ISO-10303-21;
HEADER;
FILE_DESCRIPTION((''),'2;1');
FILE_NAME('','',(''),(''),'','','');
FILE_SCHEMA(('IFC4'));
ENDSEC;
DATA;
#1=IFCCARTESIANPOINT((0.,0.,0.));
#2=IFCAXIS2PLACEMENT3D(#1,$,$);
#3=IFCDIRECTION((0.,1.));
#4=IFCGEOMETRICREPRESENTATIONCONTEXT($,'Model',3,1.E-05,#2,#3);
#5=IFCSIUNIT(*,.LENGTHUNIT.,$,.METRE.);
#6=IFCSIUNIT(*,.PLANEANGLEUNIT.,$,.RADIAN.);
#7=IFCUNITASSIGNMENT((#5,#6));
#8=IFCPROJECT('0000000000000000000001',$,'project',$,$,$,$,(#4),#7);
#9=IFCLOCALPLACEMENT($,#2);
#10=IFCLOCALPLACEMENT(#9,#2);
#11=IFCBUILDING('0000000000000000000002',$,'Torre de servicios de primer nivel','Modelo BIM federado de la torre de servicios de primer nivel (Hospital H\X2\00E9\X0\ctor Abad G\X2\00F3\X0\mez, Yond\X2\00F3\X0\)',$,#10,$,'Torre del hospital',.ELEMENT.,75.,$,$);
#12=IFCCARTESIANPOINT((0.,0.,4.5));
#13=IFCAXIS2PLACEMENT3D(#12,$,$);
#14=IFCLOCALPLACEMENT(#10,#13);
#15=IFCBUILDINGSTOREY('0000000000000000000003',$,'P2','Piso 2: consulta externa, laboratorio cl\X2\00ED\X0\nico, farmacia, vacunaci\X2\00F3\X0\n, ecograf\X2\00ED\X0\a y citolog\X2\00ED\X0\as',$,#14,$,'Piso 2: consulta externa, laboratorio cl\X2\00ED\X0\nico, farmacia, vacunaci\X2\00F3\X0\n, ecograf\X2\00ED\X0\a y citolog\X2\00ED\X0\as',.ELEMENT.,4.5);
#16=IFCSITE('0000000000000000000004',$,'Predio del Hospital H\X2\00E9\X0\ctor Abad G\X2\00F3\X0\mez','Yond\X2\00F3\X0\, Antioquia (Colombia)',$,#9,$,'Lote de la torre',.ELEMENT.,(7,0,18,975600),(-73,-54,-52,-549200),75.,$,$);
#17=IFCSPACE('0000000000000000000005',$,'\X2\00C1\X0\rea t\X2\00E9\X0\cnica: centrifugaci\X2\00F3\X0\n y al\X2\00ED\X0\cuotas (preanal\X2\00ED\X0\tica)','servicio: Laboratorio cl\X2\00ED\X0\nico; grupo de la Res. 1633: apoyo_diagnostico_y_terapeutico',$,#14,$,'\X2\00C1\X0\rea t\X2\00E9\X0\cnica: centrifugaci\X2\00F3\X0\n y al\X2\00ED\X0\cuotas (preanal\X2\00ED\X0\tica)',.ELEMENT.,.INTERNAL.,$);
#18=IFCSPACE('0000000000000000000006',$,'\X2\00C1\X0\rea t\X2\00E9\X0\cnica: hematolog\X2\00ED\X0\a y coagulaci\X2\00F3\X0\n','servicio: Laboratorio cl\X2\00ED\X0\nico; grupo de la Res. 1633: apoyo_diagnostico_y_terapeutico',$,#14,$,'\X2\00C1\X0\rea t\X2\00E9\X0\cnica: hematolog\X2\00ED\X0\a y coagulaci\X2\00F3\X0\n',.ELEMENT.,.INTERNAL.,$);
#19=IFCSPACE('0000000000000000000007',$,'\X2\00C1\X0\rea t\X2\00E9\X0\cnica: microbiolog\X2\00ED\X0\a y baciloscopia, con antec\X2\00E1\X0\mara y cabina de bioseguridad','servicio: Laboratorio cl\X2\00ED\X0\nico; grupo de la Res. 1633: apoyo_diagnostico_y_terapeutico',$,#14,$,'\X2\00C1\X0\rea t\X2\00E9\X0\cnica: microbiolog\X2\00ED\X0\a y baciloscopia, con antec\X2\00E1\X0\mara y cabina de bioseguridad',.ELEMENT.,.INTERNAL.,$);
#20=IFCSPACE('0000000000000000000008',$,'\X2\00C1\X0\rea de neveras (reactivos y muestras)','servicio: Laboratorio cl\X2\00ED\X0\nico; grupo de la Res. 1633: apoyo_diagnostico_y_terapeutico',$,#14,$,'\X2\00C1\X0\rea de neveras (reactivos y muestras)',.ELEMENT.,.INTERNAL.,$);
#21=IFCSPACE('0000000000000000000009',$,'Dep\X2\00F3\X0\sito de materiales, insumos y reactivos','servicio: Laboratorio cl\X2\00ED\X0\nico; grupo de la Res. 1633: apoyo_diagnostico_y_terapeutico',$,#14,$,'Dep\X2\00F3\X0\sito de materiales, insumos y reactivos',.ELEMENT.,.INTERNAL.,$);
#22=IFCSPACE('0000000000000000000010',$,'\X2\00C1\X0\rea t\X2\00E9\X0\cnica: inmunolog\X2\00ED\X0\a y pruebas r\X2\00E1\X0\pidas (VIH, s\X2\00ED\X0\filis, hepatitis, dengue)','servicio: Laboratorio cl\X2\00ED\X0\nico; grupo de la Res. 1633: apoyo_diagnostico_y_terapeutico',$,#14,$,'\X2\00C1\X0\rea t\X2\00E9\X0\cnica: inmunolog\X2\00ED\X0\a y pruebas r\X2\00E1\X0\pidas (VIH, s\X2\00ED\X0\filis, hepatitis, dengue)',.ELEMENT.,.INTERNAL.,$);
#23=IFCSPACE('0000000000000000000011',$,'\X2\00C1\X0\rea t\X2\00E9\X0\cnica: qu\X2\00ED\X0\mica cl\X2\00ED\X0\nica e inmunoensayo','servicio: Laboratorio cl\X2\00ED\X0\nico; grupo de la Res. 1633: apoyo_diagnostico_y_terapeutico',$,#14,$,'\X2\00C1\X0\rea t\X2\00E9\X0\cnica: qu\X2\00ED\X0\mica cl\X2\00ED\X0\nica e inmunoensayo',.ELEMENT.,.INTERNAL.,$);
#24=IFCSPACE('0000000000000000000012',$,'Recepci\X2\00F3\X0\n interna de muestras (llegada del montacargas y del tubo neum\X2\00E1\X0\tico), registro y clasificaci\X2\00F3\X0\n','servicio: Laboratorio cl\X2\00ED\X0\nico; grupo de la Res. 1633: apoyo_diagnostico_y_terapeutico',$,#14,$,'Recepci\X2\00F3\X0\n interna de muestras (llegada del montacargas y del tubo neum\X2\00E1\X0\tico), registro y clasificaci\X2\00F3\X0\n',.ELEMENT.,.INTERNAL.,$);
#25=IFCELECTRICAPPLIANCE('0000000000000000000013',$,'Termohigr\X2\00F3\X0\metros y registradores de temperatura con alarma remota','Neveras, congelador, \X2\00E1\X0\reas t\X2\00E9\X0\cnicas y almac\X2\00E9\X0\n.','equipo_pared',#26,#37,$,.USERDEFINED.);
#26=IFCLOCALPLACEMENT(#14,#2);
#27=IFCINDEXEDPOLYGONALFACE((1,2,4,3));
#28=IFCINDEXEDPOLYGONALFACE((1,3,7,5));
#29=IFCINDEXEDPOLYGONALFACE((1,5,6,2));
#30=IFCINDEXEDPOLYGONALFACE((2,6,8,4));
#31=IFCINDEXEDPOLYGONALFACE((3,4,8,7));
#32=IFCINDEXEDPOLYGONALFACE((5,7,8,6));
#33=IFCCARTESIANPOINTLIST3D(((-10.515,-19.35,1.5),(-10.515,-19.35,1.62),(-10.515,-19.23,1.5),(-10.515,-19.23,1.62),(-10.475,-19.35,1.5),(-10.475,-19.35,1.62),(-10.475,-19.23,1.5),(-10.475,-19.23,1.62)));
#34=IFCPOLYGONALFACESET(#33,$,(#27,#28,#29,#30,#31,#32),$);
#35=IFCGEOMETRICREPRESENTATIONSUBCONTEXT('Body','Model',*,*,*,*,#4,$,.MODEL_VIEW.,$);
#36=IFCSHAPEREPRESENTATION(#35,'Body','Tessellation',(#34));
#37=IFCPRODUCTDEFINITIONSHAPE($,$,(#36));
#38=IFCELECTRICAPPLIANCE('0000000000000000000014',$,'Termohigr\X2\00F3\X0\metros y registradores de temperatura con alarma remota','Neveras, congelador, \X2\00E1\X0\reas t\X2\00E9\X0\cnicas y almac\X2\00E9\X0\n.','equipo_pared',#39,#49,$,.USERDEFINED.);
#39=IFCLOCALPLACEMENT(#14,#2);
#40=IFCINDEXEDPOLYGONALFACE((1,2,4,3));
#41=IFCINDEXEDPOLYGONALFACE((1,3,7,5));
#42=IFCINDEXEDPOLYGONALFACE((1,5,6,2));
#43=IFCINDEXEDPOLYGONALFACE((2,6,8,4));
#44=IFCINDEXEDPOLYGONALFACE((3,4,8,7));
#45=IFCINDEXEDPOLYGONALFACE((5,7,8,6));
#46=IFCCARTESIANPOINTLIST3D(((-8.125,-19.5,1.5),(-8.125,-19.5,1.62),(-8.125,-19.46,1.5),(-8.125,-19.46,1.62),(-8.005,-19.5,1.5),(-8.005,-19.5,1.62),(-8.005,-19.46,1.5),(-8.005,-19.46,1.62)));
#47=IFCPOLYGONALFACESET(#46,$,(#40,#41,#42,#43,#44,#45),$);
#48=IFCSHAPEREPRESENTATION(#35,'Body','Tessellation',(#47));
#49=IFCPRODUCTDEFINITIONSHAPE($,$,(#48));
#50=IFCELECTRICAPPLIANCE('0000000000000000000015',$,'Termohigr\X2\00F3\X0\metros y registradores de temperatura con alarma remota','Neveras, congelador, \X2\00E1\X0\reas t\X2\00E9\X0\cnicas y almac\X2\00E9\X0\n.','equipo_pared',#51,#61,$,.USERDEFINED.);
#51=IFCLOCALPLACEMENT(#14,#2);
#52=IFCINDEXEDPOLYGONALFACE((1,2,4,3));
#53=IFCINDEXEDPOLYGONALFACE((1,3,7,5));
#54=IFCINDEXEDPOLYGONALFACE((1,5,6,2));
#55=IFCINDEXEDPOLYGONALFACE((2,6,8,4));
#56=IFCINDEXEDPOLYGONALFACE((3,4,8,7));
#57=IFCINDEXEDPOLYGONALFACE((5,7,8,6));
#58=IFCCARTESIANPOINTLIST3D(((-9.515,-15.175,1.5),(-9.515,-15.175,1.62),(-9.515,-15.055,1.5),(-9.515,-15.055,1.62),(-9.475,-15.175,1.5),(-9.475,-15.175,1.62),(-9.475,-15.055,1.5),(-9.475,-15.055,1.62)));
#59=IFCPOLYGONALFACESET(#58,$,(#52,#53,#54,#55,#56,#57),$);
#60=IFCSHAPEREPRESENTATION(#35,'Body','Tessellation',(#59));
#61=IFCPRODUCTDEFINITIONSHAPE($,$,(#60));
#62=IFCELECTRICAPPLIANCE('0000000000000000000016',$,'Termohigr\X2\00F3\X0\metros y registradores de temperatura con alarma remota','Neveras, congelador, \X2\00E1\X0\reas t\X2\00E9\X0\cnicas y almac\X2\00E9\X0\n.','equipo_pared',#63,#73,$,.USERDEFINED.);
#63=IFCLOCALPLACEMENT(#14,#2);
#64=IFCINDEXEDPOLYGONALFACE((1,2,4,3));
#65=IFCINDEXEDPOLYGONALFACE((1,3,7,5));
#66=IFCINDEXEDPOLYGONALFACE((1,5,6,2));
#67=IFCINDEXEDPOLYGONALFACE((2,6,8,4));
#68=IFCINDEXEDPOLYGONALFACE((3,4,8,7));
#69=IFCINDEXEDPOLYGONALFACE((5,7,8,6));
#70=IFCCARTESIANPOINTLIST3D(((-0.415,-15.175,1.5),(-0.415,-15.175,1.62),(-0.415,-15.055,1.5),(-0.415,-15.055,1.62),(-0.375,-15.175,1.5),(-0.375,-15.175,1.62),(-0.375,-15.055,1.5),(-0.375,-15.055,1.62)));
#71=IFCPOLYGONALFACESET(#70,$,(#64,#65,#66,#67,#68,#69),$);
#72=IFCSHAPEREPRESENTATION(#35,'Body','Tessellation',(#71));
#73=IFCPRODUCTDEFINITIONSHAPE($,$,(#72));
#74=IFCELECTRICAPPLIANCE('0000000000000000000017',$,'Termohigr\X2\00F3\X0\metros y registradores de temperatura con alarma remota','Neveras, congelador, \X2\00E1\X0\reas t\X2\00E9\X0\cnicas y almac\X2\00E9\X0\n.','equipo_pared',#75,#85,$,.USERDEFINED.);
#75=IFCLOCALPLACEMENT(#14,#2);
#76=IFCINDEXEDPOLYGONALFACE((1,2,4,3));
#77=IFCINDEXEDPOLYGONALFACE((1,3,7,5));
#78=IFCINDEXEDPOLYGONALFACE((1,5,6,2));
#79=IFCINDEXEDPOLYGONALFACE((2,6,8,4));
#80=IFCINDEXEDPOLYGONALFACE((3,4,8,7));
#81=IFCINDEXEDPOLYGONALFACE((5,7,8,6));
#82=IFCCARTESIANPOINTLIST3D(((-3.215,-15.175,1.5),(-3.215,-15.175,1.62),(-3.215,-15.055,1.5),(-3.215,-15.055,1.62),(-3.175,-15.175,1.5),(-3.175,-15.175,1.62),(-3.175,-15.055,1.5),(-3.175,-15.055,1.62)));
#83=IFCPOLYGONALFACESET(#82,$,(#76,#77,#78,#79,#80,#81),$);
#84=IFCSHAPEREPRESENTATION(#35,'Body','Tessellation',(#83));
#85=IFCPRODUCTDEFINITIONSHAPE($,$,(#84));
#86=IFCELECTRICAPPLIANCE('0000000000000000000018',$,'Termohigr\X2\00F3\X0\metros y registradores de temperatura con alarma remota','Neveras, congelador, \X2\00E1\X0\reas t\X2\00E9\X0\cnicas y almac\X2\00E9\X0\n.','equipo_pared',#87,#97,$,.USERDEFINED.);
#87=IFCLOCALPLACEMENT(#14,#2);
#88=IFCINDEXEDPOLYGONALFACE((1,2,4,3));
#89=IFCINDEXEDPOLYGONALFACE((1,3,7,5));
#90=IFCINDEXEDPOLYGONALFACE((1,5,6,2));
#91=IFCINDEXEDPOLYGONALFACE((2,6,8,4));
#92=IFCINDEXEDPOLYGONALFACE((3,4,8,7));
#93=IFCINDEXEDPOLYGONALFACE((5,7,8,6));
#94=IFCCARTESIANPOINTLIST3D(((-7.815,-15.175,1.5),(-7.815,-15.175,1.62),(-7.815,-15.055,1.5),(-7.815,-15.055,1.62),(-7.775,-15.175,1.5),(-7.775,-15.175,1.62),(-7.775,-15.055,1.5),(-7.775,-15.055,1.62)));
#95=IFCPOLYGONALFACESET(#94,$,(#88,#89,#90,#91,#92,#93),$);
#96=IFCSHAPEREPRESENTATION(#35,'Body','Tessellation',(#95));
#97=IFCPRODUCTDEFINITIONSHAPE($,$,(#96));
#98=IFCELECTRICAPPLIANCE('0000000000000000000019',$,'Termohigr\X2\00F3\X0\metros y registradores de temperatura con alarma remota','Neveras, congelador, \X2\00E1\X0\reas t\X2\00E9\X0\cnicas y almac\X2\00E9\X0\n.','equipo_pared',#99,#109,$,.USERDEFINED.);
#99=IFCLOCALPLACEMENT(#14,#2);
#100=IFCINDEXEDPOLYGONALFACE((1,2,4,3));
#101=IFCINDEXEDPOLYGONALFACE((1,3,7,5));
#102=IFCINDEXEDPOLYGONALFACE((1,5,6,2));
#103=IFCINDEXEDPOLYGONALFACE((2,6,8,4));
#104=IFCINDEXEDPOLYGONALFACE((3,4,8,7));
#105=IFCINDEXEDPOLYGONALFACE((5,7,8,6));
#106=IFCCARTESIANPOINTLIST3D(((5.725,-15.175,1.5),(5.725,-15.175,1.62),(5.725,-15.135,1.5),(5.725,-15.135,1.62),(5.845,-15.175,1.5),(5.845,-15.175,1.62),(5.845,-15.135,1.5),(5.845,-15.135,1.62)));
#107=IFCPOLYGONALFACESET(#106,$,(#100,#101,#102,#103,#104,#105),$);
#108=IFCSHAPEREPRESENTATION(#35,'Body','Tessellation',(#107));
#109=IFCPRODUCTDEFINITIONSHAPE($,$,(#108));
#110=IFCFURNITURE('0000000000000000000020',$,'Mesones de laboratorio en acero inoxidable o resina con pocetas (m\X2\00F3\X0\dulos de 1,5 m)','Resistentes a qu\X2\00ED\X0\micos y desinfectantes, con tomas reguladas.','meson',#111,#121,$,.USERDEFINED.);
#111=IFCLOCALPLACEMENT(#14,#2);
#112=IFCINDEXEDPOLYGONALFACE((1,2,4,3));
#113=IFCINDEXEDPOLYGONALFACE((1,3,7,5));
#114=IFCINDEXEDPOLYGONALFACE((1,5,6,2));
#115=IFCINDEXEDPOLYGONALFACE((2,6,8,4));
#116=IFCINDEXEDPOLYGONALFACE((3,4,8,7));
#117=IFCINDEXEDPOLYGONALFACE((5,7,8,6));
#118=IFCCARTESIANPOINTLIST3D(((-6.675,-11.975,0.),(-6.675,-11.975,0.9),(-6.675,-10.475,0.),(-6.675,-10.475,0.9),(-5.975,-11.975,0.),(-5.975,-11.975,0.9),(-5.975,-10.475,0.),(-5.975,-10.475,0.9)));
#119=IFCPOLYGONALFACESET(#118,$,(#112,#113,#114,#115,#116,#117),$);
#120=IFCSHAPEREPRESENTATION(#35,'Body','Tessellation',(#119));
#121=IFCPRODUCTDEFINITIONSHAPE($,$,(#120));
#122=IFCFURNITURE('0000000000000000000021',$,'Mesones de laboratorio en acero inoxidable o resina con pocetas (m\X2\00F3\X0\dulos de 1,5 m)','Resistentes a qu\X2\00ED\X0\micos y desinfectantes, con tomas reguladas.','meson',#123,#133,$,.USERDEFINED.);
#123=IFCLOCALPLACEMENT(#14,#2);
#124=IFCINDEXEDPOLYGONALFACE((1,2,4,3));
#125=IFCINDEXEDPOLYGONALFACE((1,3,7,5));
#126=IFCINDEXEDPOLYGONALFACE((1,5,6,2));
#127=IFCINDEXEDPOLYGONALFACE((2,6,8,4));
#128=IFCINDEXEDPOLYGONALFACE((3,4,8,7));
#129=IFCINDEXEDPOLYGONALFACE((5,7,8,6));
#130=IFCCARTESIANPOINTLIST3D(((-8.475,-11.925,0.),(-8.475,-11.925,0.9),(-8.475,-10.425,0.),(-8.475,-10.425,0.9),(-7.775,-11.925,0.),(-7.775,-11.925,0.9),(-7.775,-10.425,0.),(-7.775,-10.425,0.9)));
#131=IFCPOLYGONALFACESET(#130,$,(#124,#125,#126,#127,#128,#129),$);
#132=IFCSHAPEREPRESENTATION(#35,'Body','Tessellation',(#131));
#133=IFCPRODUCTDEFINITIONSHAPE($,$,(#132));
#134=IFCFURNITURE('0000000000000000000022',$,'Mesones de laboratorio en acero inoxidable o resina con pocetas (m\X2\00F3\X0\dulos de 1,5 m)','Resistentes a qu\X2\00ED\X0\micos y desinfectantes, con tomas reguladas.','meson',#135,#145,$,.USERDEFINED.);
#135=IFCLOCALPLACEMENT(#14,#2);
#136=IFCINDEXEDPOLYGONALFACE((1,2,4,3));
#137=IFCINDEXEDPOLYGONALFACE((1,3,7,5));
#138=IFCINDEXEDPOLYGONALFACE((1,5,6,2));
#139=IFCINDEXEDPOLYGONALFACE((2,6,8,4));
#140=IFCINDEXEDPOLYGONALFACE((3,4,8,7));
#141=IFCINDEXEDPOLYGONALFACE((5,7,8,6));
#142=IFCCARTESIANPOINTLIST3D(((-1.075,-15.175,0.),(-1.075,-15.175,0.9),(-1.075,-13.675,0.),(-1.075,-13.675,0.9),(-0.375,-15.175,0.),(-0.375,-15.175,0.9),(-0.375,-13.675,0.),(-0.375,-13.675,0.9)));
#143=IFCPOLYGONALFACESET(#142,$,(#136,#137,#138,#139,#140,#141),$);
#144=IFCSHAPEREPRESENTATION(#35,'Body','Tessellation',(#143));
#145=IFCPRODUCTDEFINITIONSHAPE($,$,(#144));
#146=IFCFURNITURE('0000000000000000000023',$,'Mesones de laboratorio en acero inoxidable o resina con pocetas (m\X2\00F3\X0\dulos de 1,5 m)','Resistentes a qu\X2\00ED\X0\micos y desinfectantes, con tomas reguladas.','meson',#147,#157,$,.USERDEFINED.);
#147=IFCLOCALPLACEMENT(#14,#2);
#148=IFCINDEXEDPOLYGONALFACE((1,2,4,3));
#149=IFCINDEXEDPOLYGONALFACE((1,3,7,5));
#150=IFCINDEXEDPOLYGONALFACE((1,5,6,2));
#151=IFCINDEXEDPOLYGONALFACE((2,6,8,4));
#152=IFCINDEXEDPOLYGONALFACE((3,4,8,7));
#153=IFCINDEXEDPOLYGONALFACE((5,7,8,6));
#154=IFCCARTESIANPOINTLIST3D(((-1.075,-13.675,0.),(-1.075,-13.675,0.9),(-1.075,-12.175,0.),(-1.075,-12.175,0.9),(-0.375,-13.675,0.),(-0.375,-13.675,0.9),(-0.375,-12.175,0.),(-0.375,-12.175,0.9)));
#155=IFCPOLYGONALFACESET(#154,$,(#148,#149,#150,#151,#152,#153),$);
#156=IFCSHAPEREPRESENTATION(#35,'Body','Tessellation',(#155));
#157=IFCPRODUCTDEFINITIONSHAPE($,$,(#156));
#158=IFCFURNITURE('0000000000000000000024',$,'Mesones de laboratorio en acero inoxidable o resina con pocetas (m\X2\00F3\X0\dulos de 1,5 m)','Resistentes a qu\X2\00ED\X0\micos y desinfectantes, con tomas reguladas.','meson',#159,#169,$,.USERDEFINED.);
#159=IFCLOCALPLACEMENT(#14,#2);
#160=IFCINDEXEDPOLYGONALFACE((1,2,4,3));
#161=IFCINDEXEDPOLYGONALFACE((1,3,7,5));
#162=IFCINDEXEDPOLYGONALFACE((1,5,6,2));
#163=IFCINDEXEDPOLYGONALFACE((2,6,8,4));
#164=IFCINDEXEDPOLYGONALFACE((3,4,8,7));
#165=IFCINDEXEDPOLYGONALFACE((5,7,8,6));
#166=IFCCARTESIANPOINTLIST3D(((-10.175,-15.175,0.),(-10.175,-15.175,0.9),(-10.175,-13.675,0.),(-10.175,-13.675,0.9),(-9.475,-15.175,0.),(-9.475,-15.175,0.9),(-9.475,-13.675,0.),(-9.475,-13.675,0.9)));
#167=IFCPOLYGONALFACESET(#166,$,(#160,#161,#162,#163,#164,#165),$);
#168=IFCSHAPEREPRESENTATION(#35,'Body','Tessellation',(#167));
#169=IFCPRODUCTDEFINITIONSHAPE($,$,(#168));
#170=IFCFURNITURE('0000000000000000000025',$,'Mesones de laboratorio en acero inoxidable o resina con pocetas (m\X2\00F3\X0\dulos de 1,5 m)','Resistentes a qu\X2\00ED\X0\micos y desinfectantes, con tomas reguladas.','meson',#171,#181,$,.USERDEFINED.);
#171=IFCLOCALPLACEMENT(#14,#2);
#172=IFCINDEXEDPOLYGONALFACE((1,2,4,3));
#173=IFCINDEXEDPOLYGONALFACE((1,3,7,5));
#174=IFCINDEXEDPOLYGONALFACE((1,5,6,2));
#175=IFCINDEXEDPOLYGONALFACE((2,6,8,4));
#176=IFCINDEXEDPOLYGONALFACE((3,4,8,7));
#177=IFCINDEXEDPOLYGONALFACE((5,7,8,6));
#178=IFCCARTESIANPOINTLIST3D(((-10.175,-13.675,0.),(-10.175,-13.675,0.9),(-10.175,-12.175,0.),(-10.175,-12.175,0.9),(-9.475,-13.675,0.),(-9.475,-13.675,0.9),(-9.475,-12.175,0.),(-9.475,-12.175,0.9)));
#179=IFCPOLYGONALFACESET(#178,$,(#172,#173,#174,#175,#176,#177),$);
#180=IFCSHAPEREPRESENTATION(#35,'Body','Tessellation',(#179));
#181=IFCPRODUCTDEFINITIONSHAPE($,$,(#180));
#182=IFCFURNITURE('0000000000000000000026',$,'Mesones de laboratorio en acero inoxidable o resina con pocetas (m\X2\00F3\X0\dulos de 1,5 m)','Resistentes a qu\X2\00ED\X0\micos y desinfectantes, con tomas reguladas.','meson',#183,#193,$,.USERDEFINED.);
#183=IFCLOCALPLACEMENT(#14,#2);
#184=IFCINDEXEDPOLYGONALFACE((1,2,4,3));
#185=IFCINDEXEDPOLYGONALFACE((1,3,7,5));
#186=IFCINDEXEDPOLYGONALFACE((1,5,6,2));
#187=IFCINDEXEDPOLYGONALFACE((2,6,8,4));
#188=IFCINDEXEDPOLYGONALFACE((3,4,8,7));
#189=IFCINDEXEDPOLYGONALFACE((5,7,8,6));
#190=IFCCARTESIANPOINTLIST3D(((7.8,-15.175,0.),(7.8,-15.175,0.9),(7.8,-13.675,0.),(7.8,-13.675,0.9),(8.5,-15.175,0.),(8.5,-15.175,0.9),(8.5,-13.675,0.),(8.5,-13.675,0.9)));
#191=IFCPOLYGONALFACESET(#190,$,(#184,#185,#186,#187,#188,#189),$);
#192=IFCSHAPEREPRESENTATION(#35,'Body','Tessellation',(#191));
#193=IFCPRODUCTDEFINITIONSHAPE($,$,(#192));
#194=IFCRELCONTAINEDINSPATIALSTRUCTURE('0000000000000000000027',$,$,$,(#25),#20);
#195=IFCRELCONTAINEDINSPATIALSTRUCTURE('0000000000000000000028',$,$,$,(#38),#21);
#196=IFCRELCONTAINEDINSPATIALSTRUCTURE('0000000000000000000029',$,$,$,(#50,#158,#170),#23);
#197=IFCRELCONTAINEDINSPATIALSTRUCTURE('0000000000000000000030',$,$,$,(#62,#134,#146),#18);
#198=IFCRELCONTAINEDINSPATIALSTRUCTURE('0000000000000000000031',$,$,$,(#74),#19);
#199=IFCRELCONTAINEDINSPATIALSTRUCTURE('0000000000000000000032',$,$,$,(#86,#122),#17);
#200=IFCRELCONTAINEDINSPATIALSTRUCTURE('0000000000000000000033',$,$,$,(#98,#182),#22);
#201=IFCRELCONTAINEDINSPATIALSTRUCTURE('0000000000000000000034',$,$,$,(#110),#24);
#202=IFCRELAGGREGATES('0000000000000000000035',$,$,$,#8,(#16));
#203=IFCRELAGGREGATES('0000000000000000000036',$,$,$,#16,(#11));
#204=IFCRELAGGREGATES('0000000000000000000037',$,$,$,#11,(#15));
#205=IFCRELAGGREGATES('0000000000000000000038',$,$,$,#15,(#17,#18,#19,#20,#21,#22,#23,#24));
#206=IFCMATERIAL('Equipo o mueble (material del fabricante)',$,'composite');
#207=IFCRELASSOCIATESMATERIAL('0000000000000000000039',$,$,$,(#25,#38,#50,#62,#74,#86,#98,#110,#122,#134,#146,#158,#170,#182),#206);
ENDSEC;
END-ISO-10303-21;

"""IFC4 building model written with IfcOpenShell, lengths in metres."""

from ifc_helpers import new_model, si_unit, direction, frame, origin, place, context, subcontext, project, spatial, rectangle, extrude, material, element, save


model = new_model("IFC4")

# Units and contexts
model_context = context("Model", 3, precision=1e-05, world=origin(), true_north=direction((0.0, 1.0)))
body_context = subcontext(model_context, "Body", "Model", "MODEL_VIEW")
ifc_project = project(units=[si_unit("LENGTHUNIT", "METRE"), si_unit("PLANEANGLEUNIT", "RADIAN")], contexts=[model_context])

# Site, building, storey, space
site_placement = place(None, origin())
site = spatial("IfcSite", under=ifc_project, at=site_placement, Name="Predio del Hospital Héctor Abad Gómez", Description="Yondó, Antioquia (Colombia)", LongName="Lote de la torre", CompositionType="ELEMENT", RefLatitude=(7, 0, 18, 975600), RefLongitude=(-73, -54, -52, -549200), RefElevation=75.0)
building_placement = place(site_placement, origin())
building = spatial("IfcBuilding", under=site, at=building_placement, Name="Torre de servicios de primer nivel", Description="Modelo BIM federado de la torre de servicios de primer nivel (Hospital Héctor Abad Gómez, Yondó)", LongName="Torre del hospital", CompositionType="ELEMENT", ElevationOfRefHeight=75.0)
placement = place(building_placement, frame((0.0, 0.0, 4.5)))
storey = spatial("IfcBuildingStorey", under=building, at=placement, Name="P2", Description="Piso 2: consulta externa, laboratorio clínico, farmacia, vacunación, ecografía y citologías", LongName="Piso 2: consulta externa, laboratorio clínico, farmacia, vacunación, ecografía y citologías", CompositionType="ELEMENT", Elevation=4.5)
space_1 = spatial("IfcSpace", under=storey, at=placement, Name="Área técnica: centrifugación y alícuotas (preanalítica)", Description="servicio: Laboratorio clínico; grupo de la Res. 1633: apoyo_diagnostico_y_terapeutico", LongName="Área técnica: centrifugación y alícuotas (preanalítica)", CompositionType="ELEMENT", PredefinedType="INTERNAL")

# Shared definitions
ifc_material = material(Name="Equipo o mueble (material del fabricante)", Category="composite")

# Shared definitions
space_2 = spatial("IfcSpace", under=storey, at=placement, Name="Área técnica: hematología y coagulación", Description="servicio: Laboratorio clínico; grupo de la Res. 1633: apoyo_diagnostico_y_terapeutico", LongName="Área técnica: hematología y coagulación", CompositionType="ELEMENT", PredefinedType="INTERNAL")

# Shared definitions
space_3 = spatial("IfcSpace", under=storey, at=placement, Name="Área técnica: microbiología y baciloscopia, con antecámara y cabina de bioseguridad", Description="servicio: Laboratorio clínico; grupo de la Res. 1633: apoyo_diagnostico_y_terapeutico", LongName="Área técnica: microbiología y baciloscopia, con antecámara y cabina de bioseguridad", CompositionType="ELEMENT", PredefinedType="INTERNAL")

# Shared definitions
space_4 = spatial("IfcSpace", under=storey, at=placement, Name="Área de neveras (reactivos y muestras)", Description="servicio: Laboratorio clínico; grupo de la Res. 1633: apoyo_diagnostico_y_terapeutico", LongName="Área de neveras (reactivos y muestras)", CompositionType="ELEMENT", PredefinedType="INTERNAL")

# Shared definitions
space_5 = spatial("IfcSpace", under=storey, at=placement, Name="Depósito de materiales, insumos y reactivos", Description="servicio: Laboratorio clínico; grupo de la Res. 1633: apoyo_diagnostico_y_terapeutico", LongName="Depósito de materiales, insumos y reactivos", CompositionType="ELEMENT", PredefinedType="INTERNAL")

# Shared definitions
space_6 = spatial("IfcSpace", under=storey, at=placement, Name="Área técnica: inmunología y pruebas rápidas (VIH, sífilis, hepatitis, dengue)", Description="servicio: Laboratorio clínico; grupo de la Res. 1633: apoyo_diagnostico_y_terapeutico", LongName="Área técnica: inmunología y pruebas rápidas (VIH, sífilis, hepatitis, dengue)", CompositionType="ELEMENT", PredefinedType="INTERNAL")

# Shared definitions
space_7 = spatial("IfcSpace", under=storey, at=placement, Name="Área técnica: química clínica e inmunoensayo", Description="servicio: Laboratorio clínico; grupo de la Res. 1633: apoyo_diagnostico_y_terapeutico", LongName="Área técnica: química clínica e inmunoensayo", CompositionType="ELEMENT", PredefinedType="INTERNAL")

# Electric appliances
element("IfcElectricAppliance", 1, at=placement, inside=space_4, material=ifc_material, Name="Termohigrómetros y registradores de temperatura con alarma remota", Description="Neveras, congelador, áreas técnicas y almacén.", ObjectType="equipo_pared", PredefinedType="USERDEFINED", context=body_context, shape_type="SweptSolid", body=[
    extrude(rectangle(XDim=0.12, YDim=0.04), frame((-10.495, -19.29, 1.5), z_axis=(0.0, 0.0, 1.0), x_axis=(0.0, 1.0, 0.0)), (0.0, 0.0, 1.0), 0.12),
])
element("IfcElectricAppliance", 2, at=placement, inside=space_5, material=ifc_material, Name="Termohigrómetros y registradores de temperatura con alarma remota", Description="Neveras, congelador, áreas técnicas y almacén.", ObjectType="equipo_pared", PredefinedType="USERDEFINED", context=body_context, shape_type="SweptSolid", body=[
    extrude(rectangle(XDim=0.12, YDim=0.04), frame((-8.065, -19.48, 1.5)), (0.0, 0.0, 1.0), 0.12),
])
element("IfcElectricAppliance", 3, at=placement, inside=space_7, material=ifc_material, Name="Termohigrómetros y registradores de temperatura con alarma remota", Description="Neveras, congelador, áreas técnicas y almacén.", ObjectType="equipo_pared", PredefinedType="USERDEFINED", context=body_context, shape_type="SweptSolid", body=[
    extrude(rectangle(XDim=0.12, YDim=0.04), frame((-9.495, -15.115, 1.5), z_axis=(0.0, 0.0, 1.0), x_axis=(0.0, 1.0, 0.0)), (0.0, 0.0, 1.0), 0.12),
])
element("IfcElectricAppliance", 4, at=placement, inside=space_2, material=ifc_material, Name="Termohigrómetros y registradores de temperatura con alarma remota", Description="Neveras, congelador, áreas técnicas y almacén.", ObjectType="equipo_pared", PredefinedType="USERDEFINED", context=body_context, shape_type="SweptSolid", body=[
    extrude(rectangle(XDim=0.12, YDim=0.04), frame((-0.395, -15.115, 1.5), z_axis=(0.0, 0.0, 1.0), x_axis=(0.0, 1.0, 0.0)), (0.0, 0.0, 1.0), 0.12),
])
element("IfcElectricAppliance", 5, at=placement, inside=space_3, material=ifc_material, Name="Termohigrómetros y registradores de temperatura con alarma remota", Description="Neveras, congelador, áreas técnicas y almacén.", ObjectType="equipo_pared", PredefinedType="USERDEFINED", context=body_context, shape_type="SweptSolid", body=[
    extrude(rectangle(XDim=0.12, YDim=0.04), frame((-3.195, -15.115, 1.5), z_axis=(0.0, 0.0, 1.0), x_axis=(0.0, 1.0, 0.0)), (0.0, 0.0, 1.0), 0.12),
])
element("IfcElectricAppliance", 6, at=placement, inside=space_1, material=ifc_material, Name="Termohigrómetros y registradores de temperatura con alarma remota", Description="Neveras, congelador, áreas técnicas y almacén.", ObjectType="equipo_pared", PredefinedType="USERDEFINED", context=body_context, shape_type="SweptSolid", body=[
    extrude(rectangle(XDim=0.12, YDim=0.04), frame((-7.795, -15.115, 1.5), z_axis=(0.0, 0.0, 1.0), x_axis=(0.0, 1.0, 0.0)), (0.0, 0.0, 1.0), 0.12),
])
element("IfcElectricAppliance", 7, at=placement, inside=space_6, material=ifc_material, Name="Termohigrómetros y registradores de temperatura con alarma remota", Description="Neveras, congelador, áreas técnicas y almacén.", ObjectType="equipo_pared", PredefinedType="USERDEFINED", context=body_context, shape_type="SweptSolid", body=[
    extrude(rectangle(XDim=0.12, YDim=0.04), frame((5.785, -15.155, 1.5)), (0.0, 0.0, 1.0), 0.12),
])

# Shared definitions
space_8 = spatial("IfcSpace", under=storey, at=placement, Name="Recepción interna de muestras (llegada del montacargas y del tubo neumático), registro y clasificación", Description="servicio: Laboratorio clínico; grupo de la Res. 1633: apoyo_diagnostico_y_terapeutico", LongName="Recepción interna de muestras (llegada del montacargas y del tubo neumático), registro y clasificación", CompositionType="ELEMENT", PredefinedType="INTERNAL")

# Furniture
element("IfcFurniture", 8, at=placement, inside=space_8, material=ifc_material, Name="Mesones de laboratorio en acero inoxidable o resina con pocetas (módulos de 1,5 m)", Description="Resistentes a químicos y desinfectantes, con tomas reguladas.", ObjectType="meson", PredefinedType="USERDEFINED", context=body_context, shape_type="SweptSolid", body=[
    extrude(rectangle(XDim=1.5, YDim=0.7), frame((-6.325, -11.225, 0.0), z_axis=(0.0, 0.0, 1.0), x_axis=(0.0, 1.0, 0.0)), (0.0, 0.0, 1.0), 0.9),
])
element("IfcFurniture", 9, at=placement, inside=space_1, material=ifc_material, Name="Mesones de laboratorio en acero inoxidable o resina con pocetas (módulos de 1,5 m)", Description="Resistentes a químicos y desinfectantes, con tomas reguladas.", ObjectType="meson", PredefinedType="USERDEFINED", context=body_context, shape_type="SweptSolid", body=[
    extrude(rectangle(XDim=1.5, YDim=0.7), frame((-8.125, -11.175, 0.0), z_axis=(0.0, 0.0, 1.0), x_axis=(0.0, 1.0, 0.0)), (0.0, 0.0, 1.0), 0.9),
])
element("IfcFurniture", 10, at=placement, inside=space_2, material=ifc_material, Name="Mesones de laboratorio en acero inoxidable o resina con pocetas (módulos de 1,5 m)", Description="Resistentes a químicos y desinfectantes, con tomas reguladas.", ObjectType="meson", PredefinedType="USERDEFINED", context=body_context, shape_type="SweptSolid", body=[
    extrude(rectangle(XDim=1.5, YDim=0.7), frame((-0.725, -14.425, 0.0), z_axis=(0.0, 0.0, 1.0), x_axis=(0.0, 1.0, 0.0)), (0.0, 0.0, 1.0), 0.9),
])
element("IfcFurniture", 11, at=placement, inside=space_2, material=ifc_material, Name="Mesones de laboratorio en acero inoxidable o resina con pocetas (módulos de 1,5 m)", Description="Resistentes a químicos y desinfectantes, con tomas reguladas.", ObjectType="meson", PredefinedType="USERDEFINED", context=body_context, shape_type="SweptSolid", body=[
    extrude(rectangle(XDim=1.5, YDim=0.7), frame((-0.725, -12.925, 0.0), z_axis=(0.0, 0.0, 1.0), x_axis=(0.0, 1.0, 0.0)), (0.0, 0.0, 1.0), 0.9),
])
element("IfcFurniture", 12, at=placement, inside=space_7, material=ifc_material, Name="Mesones de laboratorio en acero inoxidable o resina con pocetas (módulos de 1,5 m)", Description="Resistentes a químicos y desinfectantes, con tomas reguladas.", ObjectType="meson", PredefinedType="USERDEFINED", context=body_context, shape_type="SweptSolid", body=[
    extrude(rectangle(XDim=1.5, YDim=0.7), frame((-9.825, -14.425, 0.0), z_axis=(0.0, 0.0, 1.0), x_axis=(0.0, 1.0, 0.0)), (0.0, 0.0, 1.0), 0.9),
])
element("IfcFurniture", 13, at=placement, inside=space_7, material=ifc_material, Name="Mesones de laboratorio en acero inoxidable o resina con pocetas (módulos de 1,5 m)", Description="Resistentes a químicos y desinfectantes, con tomas reguladas.", ObjectType="meson", PredefinedType="USERDEFINED", context=body_context, shape_type="SweptSolid", body=[
    extrude(rectangle(XDim=1.5, YDim=0.7), frame((-9.825, -12.925, 0.0), z_axis=(0.0, 0.0, 1.0), x_axis=(0.0, 1.0, 0.0)), (0.0, 0.0, 1.0), 0.9),
])
element("IfcFurniture", 14, at=placement, inside=space_6, material=ifc_material, Name="Mesones de laboratorio en acero inoxidable o resina con pocetas (módulos de 1,5 m)", Description="Resistentes a químicos y desinfectantes, con tomas reguladas.", ObjectType="meson", PredefinedType="USERDEFINED", context=body_context, shape_type="SweptSolid", body=[
    extrude(rectangle(XDim=1.5, YDim=0.7), frame((8.15, -14.425, 0.0), z_axis=(0.0, 0.0, 1.0), x_axis=(0.0, 1.0, 0.0)), (0.0, 0.0, 1.0), 0.9),
])

save(model, "model.ifc")
